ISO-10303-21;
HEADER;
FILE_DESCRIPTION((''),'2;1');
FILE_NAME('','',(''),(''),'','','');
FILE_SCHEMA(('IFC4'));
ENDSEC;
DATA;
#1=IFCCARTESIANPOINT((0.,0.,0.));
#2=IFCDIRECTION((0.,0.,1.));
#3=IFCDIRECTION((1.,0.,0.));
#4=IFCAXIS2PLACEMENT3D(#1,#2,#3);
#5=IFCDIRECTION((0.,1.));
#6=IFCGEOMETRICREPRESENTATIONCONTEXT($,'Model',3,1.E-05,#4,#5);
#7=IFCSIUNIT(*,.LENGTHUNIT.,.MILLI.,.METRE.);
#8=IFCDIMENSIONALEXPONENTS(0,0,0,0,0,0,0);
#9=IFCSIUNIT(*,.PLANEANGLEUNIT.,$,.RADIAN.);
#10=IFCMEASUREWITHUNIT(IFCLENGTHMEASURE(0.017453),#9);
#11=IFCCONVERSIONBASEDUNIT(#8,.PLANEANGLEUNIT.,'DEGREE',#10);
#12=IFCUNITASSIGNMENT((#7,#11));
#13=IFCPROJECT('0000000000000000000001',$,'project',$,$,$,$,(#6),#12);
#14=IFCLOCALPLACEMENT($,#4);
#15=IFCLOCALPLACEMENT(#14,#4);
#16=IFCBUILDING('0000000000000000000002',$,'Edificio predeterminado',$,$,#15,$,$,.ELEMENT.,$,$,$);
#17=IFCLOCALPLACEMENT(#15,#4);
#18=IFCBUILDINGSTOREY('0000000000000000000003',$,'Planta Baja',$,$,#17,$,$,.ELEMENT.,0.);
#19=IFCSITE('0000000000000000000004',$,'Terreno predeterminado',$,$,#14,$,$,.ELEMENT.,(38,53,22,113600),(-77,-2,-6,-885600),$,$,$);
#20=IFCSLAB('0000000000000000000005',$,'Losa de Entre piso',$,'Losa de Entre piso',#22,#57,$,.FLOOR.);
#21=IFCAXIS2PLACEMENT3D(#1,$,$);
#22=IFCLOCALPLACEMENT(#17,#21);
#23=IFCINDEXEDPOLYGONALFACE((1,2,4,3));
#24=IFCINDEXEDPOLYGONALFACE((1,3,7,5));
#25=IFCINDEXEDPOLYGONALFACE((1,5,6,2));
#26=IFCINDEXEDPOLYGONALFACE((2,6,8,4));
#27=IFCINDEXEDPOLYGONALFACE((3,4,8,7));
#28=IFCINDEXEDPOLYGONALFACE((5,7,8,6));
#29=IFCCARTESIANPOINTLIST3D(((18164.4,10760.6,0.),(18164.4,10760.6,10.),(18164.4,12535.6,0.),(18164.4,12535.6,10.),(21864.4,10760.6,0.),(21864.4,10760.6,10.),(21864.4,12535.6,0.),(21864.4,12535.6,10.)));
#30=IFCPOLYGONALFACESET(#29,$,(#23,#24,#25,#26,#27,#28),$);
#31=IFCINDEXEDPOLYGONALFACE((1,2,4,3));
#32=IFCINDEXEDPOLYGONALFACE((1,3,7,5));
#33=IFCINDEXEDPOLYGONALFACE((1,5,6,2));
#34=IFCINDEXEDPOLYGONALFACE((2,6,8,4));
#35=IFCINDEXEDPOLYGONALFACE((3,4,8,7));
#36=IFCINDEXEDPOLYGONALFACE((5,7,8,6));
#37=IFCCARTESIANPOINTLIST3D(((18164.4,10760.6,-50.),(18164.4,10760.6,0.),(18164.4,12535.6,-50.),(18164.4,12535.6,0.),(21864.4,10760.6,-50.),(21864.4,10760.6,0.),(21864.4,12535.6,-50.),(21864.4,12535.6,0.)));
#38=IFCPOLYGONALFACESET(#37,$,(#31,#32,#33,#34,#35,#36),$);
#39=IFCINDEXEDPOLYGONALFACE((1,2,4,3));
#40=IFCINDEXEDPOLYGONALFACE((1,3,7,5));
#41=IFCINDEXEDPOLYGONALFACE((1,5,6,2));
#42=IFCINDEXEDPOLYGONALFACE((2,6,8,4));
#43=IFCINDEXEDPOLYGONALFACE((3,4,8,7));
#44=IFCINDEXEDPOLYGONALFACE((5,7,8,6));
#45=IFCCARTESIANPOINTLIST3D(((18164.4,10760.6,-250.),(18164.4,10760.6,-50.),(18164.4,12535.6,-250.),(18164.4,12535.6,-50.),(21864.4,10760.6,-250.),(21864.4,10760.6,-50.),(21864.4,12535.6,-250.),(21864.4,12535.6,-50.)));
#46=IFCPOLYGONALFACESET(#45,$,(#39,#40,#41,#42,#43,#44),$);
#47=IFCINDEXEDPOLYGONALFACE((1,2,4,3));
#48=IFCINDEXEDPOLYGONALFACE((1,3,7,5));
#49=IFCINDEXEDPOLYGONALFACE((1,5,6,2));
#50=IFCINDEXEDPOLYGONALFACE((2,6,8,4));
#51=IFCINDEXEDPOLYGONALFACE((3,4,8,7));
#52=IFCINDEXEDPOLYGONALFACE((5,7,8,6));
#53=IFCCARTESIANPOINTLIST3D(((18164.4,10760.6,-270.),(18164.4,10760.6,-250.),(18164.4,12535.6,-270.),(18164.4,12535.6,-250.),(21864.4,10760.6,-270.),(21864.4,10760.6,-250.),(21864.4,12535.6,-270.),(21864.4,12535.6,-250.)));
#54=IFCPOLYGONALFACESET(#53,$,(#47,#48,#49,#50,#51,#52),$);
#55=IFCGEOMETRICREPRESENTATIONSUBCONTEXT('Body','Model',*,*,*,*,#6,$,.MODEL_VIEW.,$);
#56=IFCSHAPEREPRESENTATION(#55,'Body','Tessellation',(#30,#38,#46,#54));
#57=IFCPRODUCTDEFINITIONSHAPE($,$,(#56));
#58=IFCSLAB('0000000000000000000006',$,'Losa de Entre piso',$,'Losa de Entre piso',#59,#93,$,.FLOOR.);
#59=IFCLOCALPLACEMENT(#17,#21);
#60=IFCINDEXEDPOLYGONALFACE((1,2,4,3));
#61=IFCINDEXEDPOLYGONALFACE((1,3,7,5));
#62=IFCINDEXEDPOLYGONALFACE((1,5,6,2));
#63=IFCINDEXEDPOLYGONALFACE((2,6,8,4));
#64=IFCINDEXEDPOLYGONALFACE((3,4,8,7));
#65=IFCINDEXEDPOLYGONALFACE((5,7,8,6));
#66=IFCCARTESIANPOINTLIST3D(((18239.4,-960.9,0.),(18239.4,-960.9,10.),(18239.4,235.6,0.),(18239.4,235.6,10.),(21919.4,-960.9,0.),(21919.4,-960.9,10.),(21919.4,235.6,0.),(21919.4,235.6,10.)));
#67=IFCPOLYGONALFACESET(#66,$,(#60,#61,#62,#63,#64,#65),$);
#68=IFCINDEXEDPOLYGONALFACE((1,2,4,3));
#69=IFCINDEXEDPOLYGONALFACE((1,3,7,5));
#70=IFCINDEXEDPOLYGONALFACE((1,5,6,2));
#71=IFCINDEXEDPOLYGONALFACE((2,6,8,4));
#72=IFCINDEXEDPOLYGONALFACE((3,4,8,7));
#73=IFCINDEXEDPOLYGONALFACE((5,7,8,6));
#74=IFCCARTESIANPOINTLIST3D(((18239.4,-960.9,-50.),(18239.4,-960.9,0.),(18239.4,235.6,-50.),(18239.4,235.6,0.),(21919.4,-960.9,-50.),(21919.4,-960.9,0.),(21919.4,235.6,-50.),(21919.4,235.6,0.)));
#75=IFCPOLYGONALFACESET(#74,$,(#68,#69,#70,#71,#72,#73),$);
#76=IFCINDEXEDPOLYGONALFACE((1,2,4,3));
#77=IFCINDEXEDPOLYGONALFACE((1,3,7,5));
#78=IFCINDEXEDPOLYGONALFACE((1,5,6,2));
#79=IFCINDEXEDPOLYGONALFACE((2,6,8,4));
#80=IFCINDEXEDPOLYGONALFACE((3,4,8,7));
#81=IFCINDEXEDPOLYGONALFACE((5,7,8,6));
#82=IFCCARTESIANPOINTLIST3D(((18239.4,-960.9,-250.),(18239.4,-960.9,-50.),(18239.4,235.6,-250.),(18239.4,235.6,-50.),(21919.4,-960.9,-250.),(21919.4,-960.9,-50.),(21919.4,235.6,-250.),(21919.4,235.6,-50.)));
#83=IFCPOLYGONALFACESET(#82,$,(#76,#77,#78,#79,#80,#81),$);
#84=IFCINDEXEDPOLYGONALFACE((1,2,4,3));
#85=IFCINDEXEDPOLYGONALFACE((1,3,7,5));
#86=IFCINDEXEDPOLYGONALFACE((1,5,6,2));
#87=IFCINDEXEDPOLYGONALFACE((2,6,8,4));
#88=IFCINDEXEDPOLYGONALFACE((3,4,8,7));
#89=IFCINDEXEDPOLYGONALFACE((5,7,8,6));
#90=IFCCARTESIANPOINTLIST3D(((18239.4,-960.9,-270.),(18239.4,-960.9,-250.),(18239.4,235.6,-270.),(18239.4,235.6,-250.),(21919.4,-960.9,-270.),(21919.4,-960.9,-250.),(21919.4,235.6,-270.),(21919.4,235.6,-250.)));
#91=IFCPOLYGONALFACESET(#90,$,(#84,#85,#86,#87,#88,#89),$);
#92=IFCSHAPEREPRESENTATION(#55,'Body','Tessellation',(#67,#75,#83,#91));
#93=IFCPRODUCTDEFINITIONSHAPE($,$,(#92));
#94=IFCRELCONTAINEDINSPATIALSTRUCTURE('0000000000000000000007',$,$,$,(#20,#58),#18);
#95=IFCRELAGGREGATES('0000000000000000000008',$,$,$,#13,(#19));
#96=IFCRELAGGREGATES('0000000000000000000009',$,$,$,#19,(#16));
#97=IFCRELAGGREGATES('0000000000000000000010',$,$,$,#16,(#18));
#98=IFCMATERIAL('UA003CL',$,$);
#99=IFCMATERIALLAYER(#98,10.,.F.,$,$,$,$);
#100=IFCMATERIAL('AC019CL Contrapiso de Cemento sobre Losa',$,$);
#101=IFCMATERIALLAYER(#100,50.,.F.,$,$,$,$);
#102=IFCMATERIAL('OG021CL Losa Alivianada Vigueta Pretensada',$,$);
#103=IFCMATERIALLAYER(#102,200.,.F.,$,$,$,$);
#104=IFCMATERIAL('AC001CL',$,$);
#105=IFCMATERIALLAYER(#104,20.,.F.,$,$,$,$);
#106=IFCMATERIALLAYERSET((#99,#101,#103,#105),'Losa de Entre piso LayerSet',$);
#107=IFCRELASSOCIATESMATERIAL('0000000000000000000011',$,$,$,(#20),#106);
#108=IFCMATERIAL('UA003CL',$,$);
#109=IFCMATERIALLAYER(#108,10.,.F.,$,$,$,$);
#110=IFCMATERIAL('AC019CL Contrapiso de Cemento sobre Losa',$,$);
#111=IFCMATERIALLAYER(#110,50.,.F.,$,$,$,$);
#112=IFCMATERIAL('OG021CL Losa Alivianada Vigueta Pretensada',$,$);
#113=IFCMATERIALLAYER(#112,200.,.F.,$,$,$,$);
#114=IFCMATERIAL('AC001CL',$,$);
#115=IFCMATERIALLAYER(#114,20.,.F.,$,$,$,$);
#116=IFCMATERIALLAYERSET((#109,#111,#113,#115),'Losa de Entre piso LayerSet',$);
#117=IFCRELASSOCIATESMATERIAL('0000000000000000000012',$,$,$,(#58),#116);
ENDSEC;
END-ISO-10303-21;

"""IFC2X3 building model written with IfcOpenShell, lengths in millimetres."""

from ifc_helpers import new_model, entity, si_unit, converted_unit, direction, frame, origin_with_axes, place, context, subcontext, project, spatial, polyline, outline, extrude, material, layer, layer_set, layer_usage, element, save


model = new_model("IFC2X3")

# Units and contexts
model_context = context("Model", 3, precision=1e-05, world=origin_with_axes(), true_north=direction((0.0, 1.0)))
body_context = subcontext(model_context, "Body", "Model", "MODEL_VIEW")
ifc_project = project(units=[si_unit("LENGTHUNIT", "METRE", prefix="MILLI"), converted_unit("PLANEANGLEUNIT", "DEGREE", entity("IfcLengthMeasure", 0.017453), si_unit("PLANEANGLEUNIT", "RADIAN"), dimensions=[0, 0, 0, 0, 0, 0, 0])], contexts=[model_context])

# Site, building, storey
site_placement = place(None, origin_with_axes())
site = spatial("IfcSite", under=ifc_project, at=site_placement, Name="Terreno predeterminado", CompositionType="ELEMENT", RefLatitude=(38, 53, 22, 113600), RefLongitude=(-77, -2, -6, -885600))
building_placement = place(site_placement, origin_with_axes())
building = spatial("IfcBuilding", under=site, at=building_placement, Name="Edificio predeterminado", CompositionType="ELEMENT")
storey_placement = place(building_placement, origin_with_axes())
storey = spatial("IfcBuildingStorey", under=building, at=storey_placement, Name="Planta Baja", CompositionType="ELEMENT", Elevation=0.0)

# Slabs
ifc_material_1 = material(Name="UA003CL")
ifc_layer_1 = layer(ifc_material_1, 10.0, ventilated=False)
ifc_material_2 = material(Name="AC019CL Contrapiso de Cemento sobre Losa")
ifc_layer_2 = layer(ifc_material_2, 50.0, ventilated=False)
ifc_material_3 = material(Name="OG021CL Losa Alivianada Vigueta Pretensada")
ifc_layer_3 = layer(ifc_material_3, 200.0, ventilated=False)
ifc_material_4 = material(Name="AC001CL")
ifc_layer_4 = layer(ifc_material_4, 20.0, ventilated=False)
ifc_layer_set_1 = layer_set([ifc_layer_1, ifc_layer_2, ifc_layer_3, ifc_layer_4], Name="Losa de Entre piso LayerSet")
ifc_layer_usage_1 = layer_usage(ifc_layer_set_1, "AXIS3", "POSITIVE", 0.0)
slab_1_placement = place(storey_placement, origin_with_axes())
element("IfcSlab", 1, at=slab_1_placement, inside=storey, material=ifc_layer_usage_1, Name="Losa de Entre piso", ObjectType="Losa de Entre piso", PredefinedType="FLOOR", context=body_context, shape_type="SweptSolid", body=[
    extrude(outline(polyline([(0.0, 0.0), (1775.0, 0.0), (1775.0, 3700.0), (0.0, 3700.0), (0.0, 0.0)])), frame((21864.4, 12535.6, 0.0), z_axis=(0.0, 0.0, -1.0), x_axis=(0.0, -1.0, 0.0)), (0.0, 0.0, -1.0), 10.0),
    extrude(outline(polyline([(0.0, 0.0), (1775.0, 0.0), (1775.0, 3700.0), (0.0, 3700.0), (0.0, 0.0)])), frame((21864.4, 12535.6, -50.0), z_axis=(0.0, 0.0, -1.0), x_axis=(0.0, -1.0, 0.0)), (0.0, 0.0, -1.0), 50.0),
    extrude(outline(polyline([(0.0, 0.0), (1775.0, 0.0), (1775.0, 3700.0), (0.0, 3700.0), (0.0, 0.0)])), frame((21864.4, 12535.6, -250.0), z_axis=(0.0, 0.0, -1.0), x_axis=(0.0, -1.0, 0.0)), (0.0, 0.0, -1.0), 200.0),
    extrude(outline(polyline([(0.0, 0.0), (1775.0, 0.0), (1775.0, 3700.0), (0.0, 3700.0), (0.0, 0.0)])), frame((21864.4, 12535.6, -270.0), z_axis=(0.0, 0.0, -1.0), x_axis=(0.0, -1.0, 0.0)), (0.0, 0.0, -1.0), 20.0),
])
ifc_material_5 = material(Name="UA003CL")
ifc_layer_5 = layer(ifc_material_5, 10.0, ventilated=False)
ifc_material_6 = material(Name="AC019CL Contrapiso de Cemento sobre Losa")
ifc_layer_6 = layer(ifc_material_6, 50.0, ventilated=False)
ifc_material_7 = material(Name="OG021CL Losa Alivianada Vigueta Pretensada")
ifc_layer_7 = layer(ifc_material_7, 200.0, ventilated=False)
ifc_material_8 = material(Name="AC001CL")
ifc_layer_8 = layer(ifc_material_8, 20.0, ventilated=False)
ifc_layer_set_2 = layer_set([ifc_layer_5, ifc_layer_6, ifc_layer_7, ifc_layer_8], Name="Losa de Entre piso LayerSet")
ifc_layer_usage_2 = layer_usage(ifc_layer_set_2, "AXIS3", "POSITIVE", 0.0)
slab_2_placement = place(storey_placement, origin_with_axes())
element("IfcSlab", 2, at=slab_2_placement, inside=storey, material=ifc_layer_usage_2, Name="Losa de Entre piso", ObjectType="Losa de Entre piso", PredefinedType="FLOOR", context=body_context, shape_type="SweptSolid", body=[
    extrude(outline(polyline([(0.0, 0.0), (1196.6, 0.0), (1196.6, 3680.0), (0.0, 3680.0), (0.0, 0.0)])), frame((21919.4, 235.6, 0.0), z_axis=(0.0, 0.0, -1.0), x_axis=(0.0, -1.0, 0.0)), (0.0, 0.0, -1.0), 10.0),
    extrude(outline(polyline([(0.0, 0.0), (1196.6, 0.0), (1196.6, 3680.0), (0.0, 3680.0), (0.0, 0.0)])), frame((21919.4, 235.6, -50.0), z_axis=(0.0, 0.0, -1.0), x_axis=(0.0, -1.0, 0.0)), (0.0, 0.0, -1.0), 50.0),
    extrude(outline(polyline([(0.0, 0.0), (1196.6, 0.0), (1196.6, 3680.0), (0.0, 3680.0), (0.0, 0.0)])), frame((21919.4, 235.6, -250.0), z_axis=(0.0, 0.0, -1.0), x_axis=(0.0, -1.0, 0.0)), (0.0, 0.0, -1.0), 200.0),
    extrude(outline(polyline([(0.0, 0.0), (1196.6, 0.0), (1196.6, 3680.0), (0.0, 3680.0), (0.0, 0.0)])), frame((21919.4, 235.6, -270.0), z_axis=(0.0, 0.0, -1.0), x_axis=(0.0, -1.0, 0.0)), (0.0, 0.0, -1.0), 20.0),
])

save(model, "model.ifc")
